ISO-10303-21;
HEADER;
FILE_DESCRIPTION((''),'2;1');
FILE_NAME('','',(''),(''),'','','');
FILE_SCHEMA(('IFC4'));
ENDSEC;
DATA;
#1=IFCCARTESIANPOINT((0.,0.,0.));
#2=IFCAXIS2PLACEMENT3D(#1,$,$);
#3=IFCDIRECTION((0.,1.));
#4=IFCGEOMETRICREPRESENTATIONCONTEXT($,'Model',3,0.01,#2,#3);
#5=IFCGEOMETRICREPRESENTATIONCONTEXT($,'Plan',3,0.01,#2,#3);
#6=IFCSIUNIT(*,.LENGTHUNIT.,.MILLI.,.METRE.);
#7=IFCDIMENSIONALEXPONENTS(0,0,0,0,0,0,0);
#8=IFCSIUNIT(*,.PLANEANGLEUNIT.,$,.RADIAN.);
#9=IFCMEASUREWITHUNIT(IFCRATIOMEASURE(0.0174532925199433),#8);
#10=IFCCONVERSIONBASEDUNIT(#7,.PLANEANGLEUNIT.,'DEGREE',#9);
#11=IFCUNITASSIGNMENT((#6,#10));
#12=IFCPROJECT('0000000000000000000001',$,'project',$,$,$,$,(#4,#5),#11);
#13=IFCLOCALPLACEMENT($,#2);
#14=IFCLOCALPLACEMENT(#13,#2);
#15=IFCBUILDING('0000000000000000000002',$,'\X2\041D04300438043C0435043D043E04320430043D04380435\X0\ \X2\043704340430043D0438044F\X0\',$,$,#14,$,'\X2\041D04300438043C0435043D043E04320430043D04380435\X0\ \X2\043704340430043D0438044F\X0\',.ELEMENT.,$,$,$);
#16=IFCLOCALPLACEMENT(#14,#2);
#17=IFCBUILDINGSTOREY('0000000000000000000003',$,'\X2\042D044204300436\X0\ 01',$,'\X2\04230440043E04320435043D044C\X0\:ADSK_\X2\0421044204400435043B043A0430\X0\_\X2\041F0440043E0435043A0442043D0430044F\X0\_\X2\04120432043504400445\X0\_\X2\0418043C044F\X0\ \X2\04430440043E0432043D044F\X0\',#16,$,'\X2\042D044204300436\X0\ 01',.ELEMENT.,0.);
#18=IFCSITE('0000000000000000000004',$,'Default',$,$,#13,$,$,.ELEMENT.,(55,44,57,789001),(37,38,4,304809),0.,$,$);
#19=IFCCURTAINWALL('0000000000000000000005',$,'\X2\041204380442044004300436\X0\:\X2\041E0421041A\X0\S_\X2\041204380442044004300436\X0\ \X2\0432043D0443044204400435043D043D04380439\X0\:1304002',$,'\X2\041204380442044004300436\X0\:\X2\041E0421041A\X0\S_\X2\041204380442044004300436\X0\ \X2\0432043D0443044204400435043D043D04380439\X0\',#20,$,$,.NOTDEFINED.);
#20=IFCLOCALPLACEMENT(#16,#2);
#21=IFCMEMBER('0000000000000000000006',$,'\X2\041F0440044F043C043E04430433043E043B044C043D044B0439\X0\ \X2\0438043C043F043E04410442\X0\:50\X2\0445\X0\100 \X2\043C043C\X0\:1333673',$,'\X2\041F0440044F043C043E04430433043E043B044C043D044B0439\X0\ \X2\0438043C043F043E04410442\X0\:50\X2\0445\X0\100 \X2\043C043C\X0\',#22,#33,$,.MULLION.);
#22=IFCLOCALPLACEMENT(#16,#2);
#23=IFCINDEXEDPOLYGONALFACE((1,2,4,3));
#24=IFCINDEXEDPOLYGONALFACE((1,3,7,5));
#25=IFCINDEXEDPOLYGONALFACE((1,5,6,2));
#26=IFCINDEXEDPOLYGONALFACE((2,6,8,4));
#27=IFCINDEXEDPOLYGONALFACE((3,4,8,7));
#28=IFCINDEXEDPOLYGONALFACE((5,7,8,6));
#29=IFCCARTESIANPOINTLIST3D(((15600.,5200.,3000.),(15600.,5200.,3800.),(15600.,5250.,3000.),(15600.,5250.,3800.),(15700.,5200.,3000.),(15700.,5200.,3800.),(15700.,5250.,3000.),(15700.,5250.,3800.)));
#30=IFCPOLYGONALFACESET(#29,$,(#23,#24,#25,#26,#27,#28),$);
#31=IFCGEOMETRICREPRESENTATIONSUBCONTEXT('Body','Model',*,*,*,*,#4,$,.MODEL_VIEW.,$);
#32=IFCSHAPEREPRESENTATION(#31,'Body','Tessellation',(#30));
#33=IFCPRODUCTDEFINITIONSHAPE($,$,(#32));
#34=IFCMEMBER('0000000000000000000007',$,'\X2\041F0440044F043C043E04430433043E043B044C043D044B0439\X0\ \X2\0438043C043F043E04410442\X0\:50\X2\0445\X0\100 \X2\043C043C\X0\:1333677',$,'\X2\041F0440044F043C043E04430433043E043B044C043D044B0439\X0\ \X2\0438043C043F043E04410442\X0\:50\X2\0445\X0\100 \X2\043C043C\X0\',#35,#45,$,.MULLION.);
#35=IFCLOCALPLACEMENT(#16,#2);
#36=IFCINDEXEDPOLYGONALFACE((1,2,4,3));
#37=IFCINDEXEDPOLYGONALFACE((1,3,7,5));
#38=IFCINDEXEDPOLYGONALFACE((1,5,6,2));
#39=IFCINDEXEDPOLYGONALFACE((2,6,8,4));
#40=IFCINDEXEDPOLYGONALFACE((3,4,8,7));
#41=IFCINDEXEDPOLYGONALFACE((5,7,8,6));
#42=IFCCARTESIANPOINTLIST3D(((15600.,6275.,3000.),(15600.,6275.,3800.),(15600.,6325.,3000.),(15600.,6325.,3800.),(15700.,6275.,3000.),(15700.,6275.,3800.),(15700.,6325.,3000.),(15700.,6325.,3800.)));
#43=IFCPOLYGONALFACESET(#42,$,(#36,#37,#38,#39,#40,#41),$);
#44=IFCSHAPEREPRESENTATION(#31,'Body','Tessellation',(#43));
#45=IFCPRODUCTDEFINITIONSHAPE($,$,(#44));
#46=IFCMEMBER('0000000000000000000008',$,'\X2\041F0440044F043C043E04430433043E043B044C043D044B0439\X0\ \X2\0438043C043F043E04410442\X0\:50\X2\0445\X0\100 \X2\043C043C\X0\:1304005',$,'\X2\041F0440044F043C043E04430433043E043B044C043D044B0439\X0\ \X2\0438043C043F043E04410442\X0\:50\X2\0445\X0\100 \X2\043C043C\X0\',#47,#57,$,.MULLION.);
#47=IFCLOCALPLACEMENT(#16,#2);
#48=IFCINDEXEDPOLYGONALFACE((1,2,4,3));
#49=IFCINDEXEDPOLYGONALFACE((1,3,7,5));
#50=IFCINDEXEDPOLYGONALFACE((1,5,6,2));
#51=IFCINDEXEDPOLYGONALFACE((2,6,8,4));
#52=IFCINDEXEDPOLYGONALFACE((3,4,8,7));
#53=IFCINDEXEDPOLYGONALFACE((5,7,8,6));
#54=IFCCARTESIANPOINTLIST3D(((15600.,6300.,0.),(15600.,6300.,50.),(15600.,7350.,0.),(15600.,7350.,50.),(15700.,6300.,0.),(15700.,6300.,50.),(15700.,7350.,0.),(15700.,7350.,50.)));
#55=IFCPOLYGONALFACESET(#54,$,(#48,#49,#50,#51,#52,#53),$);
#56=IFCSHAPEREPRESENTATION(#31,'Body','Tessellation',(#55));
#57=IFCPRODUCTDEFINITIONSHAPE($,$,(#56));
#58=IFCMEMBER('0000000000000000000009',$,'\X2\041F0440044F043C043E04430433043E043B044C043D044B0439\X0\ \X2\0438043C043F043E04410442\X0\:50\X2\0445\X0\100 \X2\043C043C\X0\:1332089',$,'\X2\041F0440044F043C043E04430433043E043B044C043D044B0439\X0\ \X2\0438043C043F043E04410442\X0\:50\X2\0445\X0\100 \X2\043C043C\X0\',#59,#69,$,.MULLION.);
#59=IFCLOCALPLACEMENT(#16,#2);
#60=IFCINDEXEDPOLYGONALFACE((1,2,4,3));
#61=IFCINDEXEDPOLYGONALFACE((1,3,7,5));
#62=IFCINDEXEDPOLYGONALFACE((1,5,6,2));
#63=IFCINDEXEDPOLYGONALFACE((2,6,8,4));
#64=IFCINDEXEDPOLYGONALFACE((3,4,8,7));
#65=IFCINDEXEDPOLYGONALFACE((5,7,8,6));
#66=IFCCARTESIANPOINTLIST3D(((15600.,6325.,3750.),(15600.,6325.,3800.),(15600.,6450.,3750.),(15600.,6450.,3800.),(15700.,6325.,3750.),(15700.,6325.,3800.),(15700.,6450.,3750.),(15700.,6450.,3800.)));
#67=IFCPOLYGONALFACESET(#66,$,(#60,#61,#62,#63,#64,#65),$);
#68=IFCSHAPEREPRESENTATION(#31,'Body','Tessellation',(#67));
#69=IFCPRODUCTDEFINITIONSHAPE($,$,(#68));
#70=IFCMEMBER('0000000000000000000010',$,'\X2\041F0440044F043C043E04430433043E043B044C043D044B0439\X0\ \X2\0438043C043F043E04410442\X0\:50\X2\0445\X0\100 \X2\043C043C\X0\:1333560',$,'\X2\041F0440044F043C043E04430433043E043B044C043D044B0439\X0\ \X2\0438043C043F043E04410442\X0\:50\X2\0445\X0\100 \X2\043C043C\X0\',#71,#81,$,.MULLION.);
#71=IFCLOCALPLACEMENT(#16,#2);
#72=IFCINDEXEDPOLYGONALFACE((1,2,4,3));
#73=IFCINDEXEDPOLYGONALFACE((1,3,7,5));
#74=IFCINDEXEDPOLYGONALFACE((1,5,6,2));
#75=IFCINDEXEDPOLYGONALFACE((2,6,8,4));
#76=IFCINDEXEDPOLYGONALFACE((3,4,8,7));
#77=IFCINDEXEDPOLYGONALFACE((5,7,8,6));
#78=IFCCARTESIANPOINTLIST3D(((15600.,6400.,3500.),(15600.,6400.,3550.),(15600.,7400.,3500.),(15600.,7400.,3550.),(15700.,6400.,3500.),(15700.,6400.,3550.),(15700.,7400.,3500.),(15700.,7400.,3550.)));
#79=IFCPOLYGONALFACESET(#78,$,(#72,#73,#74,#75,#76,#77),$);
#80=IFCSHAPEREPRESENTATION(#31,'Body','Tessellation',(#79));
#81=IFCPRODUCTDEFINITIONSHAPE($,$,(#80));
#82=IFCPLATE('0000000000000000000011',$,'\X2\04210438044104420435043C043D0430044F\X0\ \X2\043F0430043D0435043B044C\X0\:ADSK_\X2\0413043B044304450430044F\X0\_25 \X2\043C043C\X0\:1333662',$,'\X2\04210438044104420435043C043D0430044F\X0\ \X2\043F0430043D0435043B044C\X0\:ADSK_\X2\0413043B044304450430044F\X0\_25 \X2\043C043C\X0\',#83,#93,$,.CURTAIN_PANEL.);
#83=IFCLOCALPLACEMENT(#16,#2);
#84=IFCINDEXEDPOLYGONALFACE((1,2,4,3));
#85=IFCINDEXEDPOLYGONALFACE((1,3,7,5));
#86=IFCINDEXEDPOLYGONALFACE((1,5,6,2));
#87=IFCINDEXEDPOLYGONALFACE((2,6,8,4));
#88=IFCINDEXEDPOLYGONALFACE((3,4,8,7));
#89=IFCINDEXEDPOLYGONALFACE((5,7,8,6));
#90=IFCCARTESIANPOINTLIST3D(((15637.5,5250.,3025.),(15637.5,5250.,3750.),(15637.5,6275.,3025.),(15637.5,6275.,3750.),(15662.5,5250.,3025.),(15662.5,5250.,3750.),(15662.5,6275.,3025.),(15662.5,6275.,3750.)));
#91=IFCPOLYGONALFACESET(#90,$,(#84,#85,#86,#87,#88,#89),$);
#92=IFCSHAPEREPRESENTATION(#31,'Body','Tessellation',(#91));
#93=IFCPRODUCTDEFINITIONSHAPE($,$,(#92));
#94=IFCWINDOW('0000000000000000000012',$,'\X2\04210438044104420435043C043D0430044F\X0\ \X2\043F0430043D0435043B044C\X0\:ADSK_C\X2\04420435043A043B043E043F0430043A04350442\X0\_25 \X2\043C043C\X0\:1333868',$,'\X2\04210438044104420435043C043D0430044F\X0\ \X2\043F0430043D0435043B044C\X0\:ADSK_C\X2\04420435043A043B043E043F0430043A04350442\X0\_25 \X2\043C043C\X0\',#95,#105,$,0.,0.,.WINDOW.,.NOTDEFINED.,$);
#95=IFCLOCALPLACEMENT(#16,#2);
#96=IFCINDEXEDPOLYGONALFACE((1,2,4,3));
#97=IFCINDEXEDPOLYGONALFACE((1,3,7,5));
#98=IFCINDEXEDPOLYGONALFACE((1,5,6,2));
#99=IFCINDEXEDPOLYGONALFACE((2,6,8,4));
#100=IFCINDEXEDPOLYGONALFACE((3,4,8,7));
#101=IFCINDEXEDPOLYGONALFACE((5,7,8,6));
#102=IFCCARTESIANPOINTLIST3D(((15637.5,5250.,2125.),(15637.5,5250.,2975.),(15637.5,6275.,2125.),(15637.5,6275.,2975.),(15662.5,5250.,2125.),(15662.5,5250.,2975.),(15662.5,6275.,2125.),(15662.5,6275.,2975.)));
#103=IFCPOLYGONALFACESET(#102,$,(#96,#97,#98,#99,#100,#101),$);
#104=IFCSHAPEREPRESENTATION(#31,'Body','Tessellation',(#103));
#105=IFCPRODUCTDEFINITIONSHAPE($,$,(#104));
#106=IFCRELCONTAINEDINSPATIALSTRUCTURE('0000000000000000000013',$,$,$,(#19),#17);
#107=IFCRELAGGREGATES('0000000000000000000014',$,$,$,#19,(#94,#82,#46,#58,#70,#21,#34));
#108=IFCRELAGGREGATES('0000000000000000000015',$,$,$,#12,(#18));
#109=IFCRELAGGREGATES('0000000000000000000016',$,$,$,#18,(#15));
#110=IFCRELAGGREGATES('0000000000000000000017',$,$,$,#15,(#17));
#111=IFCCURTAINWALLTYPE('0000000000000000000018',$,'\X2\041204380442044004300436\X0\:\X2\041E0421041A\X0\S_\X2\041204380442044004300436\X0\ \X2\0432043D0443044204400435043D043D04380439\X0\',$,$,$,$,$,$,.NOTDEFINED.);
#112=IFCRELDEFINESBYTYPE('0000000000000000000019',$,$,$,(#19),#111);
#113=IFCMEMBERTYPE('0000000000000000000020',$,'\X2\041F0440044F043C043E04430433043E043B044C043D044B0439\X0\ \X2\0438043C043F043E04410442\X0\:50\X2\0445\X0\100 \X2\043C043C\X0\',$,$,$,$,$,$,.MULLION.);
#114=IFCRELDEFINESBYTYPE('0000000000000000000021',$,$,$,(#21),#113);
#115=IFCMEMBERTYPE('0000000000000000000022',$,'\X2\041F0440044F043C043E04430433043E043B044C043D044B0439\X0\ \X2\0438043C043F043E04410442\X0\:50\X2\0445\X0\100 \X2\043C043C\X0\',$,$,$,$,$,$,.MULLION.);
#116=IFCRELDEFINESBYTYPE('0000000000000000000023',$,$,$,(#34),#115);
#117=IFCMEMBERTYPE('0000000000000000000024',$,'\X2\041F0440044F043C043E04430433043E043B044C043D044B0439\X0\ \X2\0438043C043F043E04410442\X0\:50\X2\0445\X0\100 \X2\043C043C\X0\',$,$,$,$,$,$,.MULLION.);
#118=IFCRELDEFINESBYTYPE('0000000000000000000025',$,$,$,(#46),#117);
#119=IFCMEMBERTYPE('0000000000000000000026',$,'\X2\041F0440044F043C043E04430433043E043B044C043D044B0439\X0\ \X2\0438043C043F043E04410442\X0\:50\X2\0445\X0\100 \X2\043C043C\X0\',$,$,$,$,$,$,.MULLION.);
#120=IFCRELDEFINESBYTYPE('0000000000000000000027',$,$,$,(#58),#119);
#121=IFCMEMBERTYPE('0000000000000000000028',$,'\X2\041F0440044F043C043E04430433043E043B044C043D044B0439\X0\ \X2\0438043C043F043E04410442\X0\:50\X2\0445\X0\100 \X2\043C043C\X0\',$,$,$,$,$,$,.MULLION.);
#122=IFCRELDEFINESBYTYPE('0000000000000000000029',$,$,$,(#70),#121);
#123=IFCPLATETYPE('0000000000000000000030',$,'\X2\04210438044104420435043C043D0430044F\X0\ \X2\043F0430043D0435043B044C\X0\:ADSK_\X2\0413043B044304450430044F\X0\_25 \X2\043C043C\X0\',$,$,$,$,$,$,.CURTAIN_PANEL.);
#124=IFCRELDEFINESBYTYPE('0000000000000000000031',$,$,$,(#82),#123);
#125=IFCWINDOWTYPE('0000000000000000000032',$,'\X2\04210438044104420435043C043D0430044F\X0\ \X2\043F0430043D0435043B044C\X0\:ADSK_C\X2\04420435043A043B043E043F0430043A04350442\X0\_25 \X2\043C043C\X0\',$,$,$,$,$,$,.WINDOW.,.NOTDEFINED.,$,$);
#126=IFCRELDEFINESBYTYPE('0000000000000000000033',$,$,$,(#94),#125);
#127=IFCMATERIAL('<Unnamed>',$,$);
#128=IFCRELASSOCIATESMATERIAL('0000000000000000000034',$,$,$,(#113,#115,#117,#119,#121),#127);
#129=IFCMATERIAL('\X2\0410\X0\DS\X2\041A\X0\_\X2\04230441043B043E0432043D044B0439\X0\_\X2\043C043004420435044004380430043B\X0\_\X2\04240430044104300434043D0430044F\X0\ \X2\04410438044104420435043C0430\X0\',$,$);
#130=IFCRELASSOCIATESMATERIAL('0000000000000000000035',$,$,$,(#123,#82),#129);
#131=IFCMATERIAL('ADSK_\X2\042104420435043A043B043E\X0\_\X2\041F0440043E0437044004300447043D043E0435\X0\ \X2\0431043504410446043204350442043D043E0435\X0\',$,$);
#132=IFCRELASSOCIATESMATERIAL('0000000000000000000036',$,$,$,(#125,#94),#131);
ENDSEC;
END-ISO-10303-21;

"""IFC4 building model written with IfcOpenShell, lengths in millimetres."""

from ifc_helpers import new_model, entity, si_unit, converted_unit, direction, frame, origin, place, context, subcontext, project, spatial, indexed_curve, outline, extrude, source, transform, mapped, material, type_object, type_shapes, element, aggregate, save


model = new_model("IFC4")

# Units and contexts
model_context = context("Model", 3, precision=0.01, world=origin(), true_north=direction((0.0, 1.0)))
plan_context = context("Plan", 3, precision=0.01, world=origin(), true_north=direction((0.0, 1.0)))
body_context = subcontext(model_context, "Body", "Model", "MODEL_VIEW")
ifc_project = project(units=[si_unit("LENGTHUNIT", "METRE", prefix="MILLI"), converted_unit("PLANEANGLEUNIT", "DEGREE", entity("IfcRatioMeasure", 0.0174532925199433), si_unit("PLANEANGLEUNIT", "RADIAN"), dimensions=[0, 0, 0, 0, 0, 0, 0])], contexts=[model_context, plan_context])

# Site, building, storey
site_placement = place(None, frame((0.0, 0.0, 0.0)))
site = spatial("IfcSite", under=ifc_project, at=site_placement, Name="Default", CompositionType="ELEMENT", RefLatitude=(55, 44, 57, 789001), RefLongitude=(37, 38, 4, 304809), RefElevation=0.0)
building_placement = place(site_placement, origin())
building = spatial("IfcBuilding", under=site, at=building_placement, Name="Наименование здания", LongName="Наименование здания", CompositionType="ELEMENT")
storey_placement = place(building_placement, origin())
storey = spatial("IfcBuildingStorey", under=building, at=storey_placement, Name="Этаж 01", ObjectType="Уровень:ADSK_Стрелка_Проектная_Вверх_Имя уровня", LongName="Этаж 01", CompositionType="ELEMENT", Elevation=0.0)

# Curtain wall, members, plate, window
curtain_wall_type = type_object("IfcCurtainWallType", Name="Витраж:ОСКS_Витраж внутренний", PredefinedType="NOTDEFINED")
curtain_wall_placement = place(storey_placement, origin())
curtain_wall = element("IfcCurtainWall", 1, at=curtain_wall_placement, inside=storey, type_object=curtain_wall_type, Name="Витраж:ОСКS_Витраж внутренний:1304002", ObjectType="Витраж:ОСКS_Витраж внутренний", PredefinedType="NOTDEFINED")
ifc_material_1 = material(Name="<Unnamed>")
member_type_1 = type_object("IfcMemberType", Name="Прямоугольный импост:50х100 мм", PredefinedType="MULLION", material=ifc_material_1)
shared_shape_1 = source(origin(), body_context, "Body", "SweptSolid", [
    extrude(outline(indexed_curve([(-50.0, -25.0), (50.0, -25.0), (50.0, 25.0), (-50.0, 25.0), (-50.0, -25.0)], self_intersect=False)), frame((-25.0, 0.0, -800.0), z_axis=(0.0, 0.0, 1.0), x_axis=(0.0, -1.0, 0.0)), (0.0, 0.0, 1.0), 800.0),
])
type_shapes(member_type_1, [shared_shape_1])
member_1_placement = place(storey_placement, frame((15650.0, 5200.0, 3000.0), z_axis=(0.0, 0.0, -1.0), x_axis=(0.0, -1.0, 0.0)))
member_1 = element("IfcMember", 2, at=member_1_placement, type_object=member_type_1, Name="Прямоугольный импост:50х100 мм:1333673", ObjectType="Прямоугольный импост:50х100 мм", PredefinedType="MULLION", context=body_context, shape_type="MappedRepresentation", body=[
    mapped(shared_shape_1, transform((0.0, 0.0, 0.0), scale=1.0)),
])
member_type_2 = type_object("IfcMemberType", Name="Прямоугольный импост:50х100 мм", PredefinedType="MULLION", material=ifc_material_1)
shared_shape_2 = source(origin(), body_context, "Body", "SweptSolid", [
    extrude(outline(indexed_curve([(-50.0, -25.0), (50.0, -25.0), (50.0, 25.0), (-50.0, 25.0), (-50.0, -25.0)], self_intersect=False)), frame((0.0, 0.0, -800.0), z_axis=(0.0, 0.0, 1.0), x_axis=(0.0, -1.0, 0.0)), (0.0, 0.0, 1.0), 800.0),
])
type_shapes(member_type_2, [shared_shape_2])
member_2_placement = place(storey_placement, frame((15650.0, 6300.0, 3000.0), z_axis=(0.0, 0.0, -1.0), x_axis=(0.0, -1.0, 0.0)))
member_2 = element("IfcMember", 3, at=member_2_placement, type_object=member_type_2, Name="Прямоугольный импост:50х100 мм:1333677", ObjectType="Прямоугольный импост:50х100 мм", PredefinedType="MULLION", context=body_context, shape_type="MappedRepresentation", body=[
    mapped(shared_shape_2, transform((0.0, 0.0, 0.0), scale=1.0)),
])
member_type_3 = type_object("IfcMemberType", Name="Прямоугольный импост:50х100 мм", PredefinedType="MULLION", material=ifc_material_1)
shared_shape_3 = source(origin(), body_context, "Body", "SweptSolid", [
    extrude(outline(indexed_curve([(-50.0, -25.0), (50.0, -25.0), (50.0, 25.0), (-50.0, 25.0), (-50.0, -25.0)], self_intersect=False)), frame((-25.0, 0.0, -1050.0), z_axis=(0.0, 0.0, 1.0), x_axis=(0.0, -1.0, 0.0)), (0.0, 0.0, 1.0), 1050.0),
])
type_shapes(member_type_3, [shared_shape_3])
member_3_placement = place(storey_placement, frame((15650.0, 7350.0, 0.0), z_axis=(0.0, 1.0, 0.0), x_axis=(0.0, 0.0, -1.0)))
member_3 = element("IfcMember", 4, at=member_3_placement, type_object=member_type_3, Name="Прямоугольный импост:50х100 мм:1304005", ObjectType="Прямоугольный импост:50х100 мм", PredefinedType="MULLION", context=body_context, shape_type="MappedRepresentation", body=[
    mapped(shared_shape_3, transform((0.0, 0.0, 0.0), scale=1.0)),
])
member_type_4 = type_object("IfcMemberType", Name="Прямоугольный импост:50х100 мм", PredefinedType="MULLION", material=ifc_material_1)
shared_shape_4 = source(origin(), body_context, "Body", "SweptSolid", [
    extrude(outline(indexed_curve([(-50.0, -25.0), (50.0, -25.0), (50.0, 25.0), (-50.0, 25.0), (-50.0, -25.0)], self_intersect=False)), frame((-25.0, 0.0, -125.0), z_axis=(0.0, 0.0, 1.0), x_axis=(0.0, -1.0, 0.0)), (0.0, 0.0, 1.0), 125.0),
])
type_shapes(member_type_4, [shared_shape_4])
member_4_placement = place(storey_placement, frame((15650.0, 6325.0, 3800.0), z_axis=(0.0, -1.0, 0.0), x_axis=(0.0, 0.0, 1.0)))
member_4 = element("IfcMember", 5, at=member_4_placement, type_object=member_type_4, Name="Прямоугольный импост:50х100 мм:1332089", ObjectType="Прямоугольный импост:50х100 мм", PredefinedType="MULLION", context=body_context, shape_type="MappedRepresentation", body=[
    mapped(shared_shape_4, transform((0.0, 0.0, 0.0), scale=1.0)),
])
member_type_5 = type_object("IfcMemberType", Name="Прямоугольный импост:50х100 мм", PredefinedType="MULLION", material=ifc_material_1)
shared_shape_5 = source(origin(), body_context, "Body", "SweptSolid", [
    extrude(outline(indexed_curve([(-50.0, -25.0), (50.0, -25.0), (50.0, 25.0), (-50.0, 25.0), (-50.0, -25.0)], self_intersect=False)), frame((-25.0, 0.0, -1000.0), z_axis=(0.0, 0.0, 1.0), x_axis=(0.0, -1.0, 0.0)), (0.0, 0.0, 1.0), 1000.0),
])
type_shapes(member_type_5, [shared_shape_5])
member_5_placement = place(storey_placement, frame((15650.0, 6400.0, 3550.0), z_axis=(0.0, -1.0, 0.0), x_axis=(0.0, 0.0, 1.0)))
member_5 = element("IfcMember", 6, at=member_5_placement, type_object=member_type_5, Name="Прямоугольный импост:50х100 мм:1333560", ObjectType="Прямоугольный импост:50х100 мм", PredefinedType="MULLION", context=body_context, shape_type="MappedRepresentation", body=[
    mapped(shared_shape_5, transform((0.0, 0.0, 0.0), scale=1.0)),
])
ifc_material_2 = material(Name="АDSК_Условный_материал_Фасадная система")
plate_type_1 = type_object("IfcPlateType", Name="Системная панель:ADSK_Глухая_25 мм", PredefinedType="CURTAIN_PANEL", material=ifc_material_2)
shared_shape_6 = source(origin(), body_context, "Body", "SweptSolid", [
    extrude(outline(indexed_curve([(-12.5, -512.5), (12.5, -512.5), (12.5, 512.5), (-12.5, 512.5), (-12.5, -512.5)], self_intersect=False)), frame((0.0, 0.0, 0.0), z_axis=(0.0, 0.0, 1.0), x_axis=(0.0, 1.0, 0.0)), (0.0, 0.0, 1.0), 725.0),
])
type_shapes(plate_type_1, [shared_shape_6])
plate_1_placement = place(curtain_wall_placement, frame((15650.0, 5762.5, 3025.0), z_axis=(0.0, 0.0, 1.0), x_axis=(0.0, -1.0, 0.0)))
plate_1 = element("IfcPlate", 7, at=plate_1_placement, type_object=plate_type_1, material=ifc_material_2, Name="Системная панель:ADSK_Глухая_25 мм:1333662", ObjectType="Системная панель:ADSK_Глухая_25 мм", PredefinedType="CURTAIN_PANEL", context=body_context, shape_type="MappedRepresentation", body=[
    mapped(shared_shape_6, transform((0.0, 0.0, 0.0), scale=1.0)),
])
ifc_material_3 = material(Name="ADSK_Стекло_Прозрачное бесцветное")
window_type = type_object("IfcWindowType", Name="Системная панель:ADSK_Cтеклопакет_25 мм", PartitioningType="NOTDEFINED", PredefinedType="WINDOW", material=ifc_material_3)
shared_shape_7 = source(origin(), body_context, "Body", "SweptSolid", [
    extrude(outline(indexed_curve([(-12.5, -512.5), (12.5, -512.5), (12.5, 512.5), (-12.5, 512.5), (-12.5, -512.5)], self_intersect=False)), frame((0.0, 0.0, 0.0), z_axis=(0.0, 0.0, 1.0), x_axis=(0.0, 1.0, 0.0)), (0.0, 0.0, 1.0), 850.0),
])
type_shapes(window_type, [shared_shape_7])
window_placement = place(curtain_wall_placement, frame((15650.0, 5762.5, 2125.0), z_axis=(0.0, 0.0, 1.0), x_axis=(0.0, -1.0, 0.0)))
window = element("IfcWindow", 8, at=window_placement, type_object=window_type, material=ifc_material_3, Name="Системная панель:ADSK_Cтеклопакет_25 мм:1333868", ObjectType="Системная панель:ADSK_Cтеклопакет_25 мм", OverallHeight=0.0, OverallWidth=0.0, PartitioningType="NOTDEFINED", PredefinedType="WINDOW", context=body_context, shape_type="MappedRepresentation", body=[
    mapped(shared_shape_7, transform((0.0, 0.0, 0.0), scale=1.0)),
])
aggregate(curtain_wall, [window, plate_1, member_3, member_4, member_5, member_1, member_2])

save(model, "model.ifc")
